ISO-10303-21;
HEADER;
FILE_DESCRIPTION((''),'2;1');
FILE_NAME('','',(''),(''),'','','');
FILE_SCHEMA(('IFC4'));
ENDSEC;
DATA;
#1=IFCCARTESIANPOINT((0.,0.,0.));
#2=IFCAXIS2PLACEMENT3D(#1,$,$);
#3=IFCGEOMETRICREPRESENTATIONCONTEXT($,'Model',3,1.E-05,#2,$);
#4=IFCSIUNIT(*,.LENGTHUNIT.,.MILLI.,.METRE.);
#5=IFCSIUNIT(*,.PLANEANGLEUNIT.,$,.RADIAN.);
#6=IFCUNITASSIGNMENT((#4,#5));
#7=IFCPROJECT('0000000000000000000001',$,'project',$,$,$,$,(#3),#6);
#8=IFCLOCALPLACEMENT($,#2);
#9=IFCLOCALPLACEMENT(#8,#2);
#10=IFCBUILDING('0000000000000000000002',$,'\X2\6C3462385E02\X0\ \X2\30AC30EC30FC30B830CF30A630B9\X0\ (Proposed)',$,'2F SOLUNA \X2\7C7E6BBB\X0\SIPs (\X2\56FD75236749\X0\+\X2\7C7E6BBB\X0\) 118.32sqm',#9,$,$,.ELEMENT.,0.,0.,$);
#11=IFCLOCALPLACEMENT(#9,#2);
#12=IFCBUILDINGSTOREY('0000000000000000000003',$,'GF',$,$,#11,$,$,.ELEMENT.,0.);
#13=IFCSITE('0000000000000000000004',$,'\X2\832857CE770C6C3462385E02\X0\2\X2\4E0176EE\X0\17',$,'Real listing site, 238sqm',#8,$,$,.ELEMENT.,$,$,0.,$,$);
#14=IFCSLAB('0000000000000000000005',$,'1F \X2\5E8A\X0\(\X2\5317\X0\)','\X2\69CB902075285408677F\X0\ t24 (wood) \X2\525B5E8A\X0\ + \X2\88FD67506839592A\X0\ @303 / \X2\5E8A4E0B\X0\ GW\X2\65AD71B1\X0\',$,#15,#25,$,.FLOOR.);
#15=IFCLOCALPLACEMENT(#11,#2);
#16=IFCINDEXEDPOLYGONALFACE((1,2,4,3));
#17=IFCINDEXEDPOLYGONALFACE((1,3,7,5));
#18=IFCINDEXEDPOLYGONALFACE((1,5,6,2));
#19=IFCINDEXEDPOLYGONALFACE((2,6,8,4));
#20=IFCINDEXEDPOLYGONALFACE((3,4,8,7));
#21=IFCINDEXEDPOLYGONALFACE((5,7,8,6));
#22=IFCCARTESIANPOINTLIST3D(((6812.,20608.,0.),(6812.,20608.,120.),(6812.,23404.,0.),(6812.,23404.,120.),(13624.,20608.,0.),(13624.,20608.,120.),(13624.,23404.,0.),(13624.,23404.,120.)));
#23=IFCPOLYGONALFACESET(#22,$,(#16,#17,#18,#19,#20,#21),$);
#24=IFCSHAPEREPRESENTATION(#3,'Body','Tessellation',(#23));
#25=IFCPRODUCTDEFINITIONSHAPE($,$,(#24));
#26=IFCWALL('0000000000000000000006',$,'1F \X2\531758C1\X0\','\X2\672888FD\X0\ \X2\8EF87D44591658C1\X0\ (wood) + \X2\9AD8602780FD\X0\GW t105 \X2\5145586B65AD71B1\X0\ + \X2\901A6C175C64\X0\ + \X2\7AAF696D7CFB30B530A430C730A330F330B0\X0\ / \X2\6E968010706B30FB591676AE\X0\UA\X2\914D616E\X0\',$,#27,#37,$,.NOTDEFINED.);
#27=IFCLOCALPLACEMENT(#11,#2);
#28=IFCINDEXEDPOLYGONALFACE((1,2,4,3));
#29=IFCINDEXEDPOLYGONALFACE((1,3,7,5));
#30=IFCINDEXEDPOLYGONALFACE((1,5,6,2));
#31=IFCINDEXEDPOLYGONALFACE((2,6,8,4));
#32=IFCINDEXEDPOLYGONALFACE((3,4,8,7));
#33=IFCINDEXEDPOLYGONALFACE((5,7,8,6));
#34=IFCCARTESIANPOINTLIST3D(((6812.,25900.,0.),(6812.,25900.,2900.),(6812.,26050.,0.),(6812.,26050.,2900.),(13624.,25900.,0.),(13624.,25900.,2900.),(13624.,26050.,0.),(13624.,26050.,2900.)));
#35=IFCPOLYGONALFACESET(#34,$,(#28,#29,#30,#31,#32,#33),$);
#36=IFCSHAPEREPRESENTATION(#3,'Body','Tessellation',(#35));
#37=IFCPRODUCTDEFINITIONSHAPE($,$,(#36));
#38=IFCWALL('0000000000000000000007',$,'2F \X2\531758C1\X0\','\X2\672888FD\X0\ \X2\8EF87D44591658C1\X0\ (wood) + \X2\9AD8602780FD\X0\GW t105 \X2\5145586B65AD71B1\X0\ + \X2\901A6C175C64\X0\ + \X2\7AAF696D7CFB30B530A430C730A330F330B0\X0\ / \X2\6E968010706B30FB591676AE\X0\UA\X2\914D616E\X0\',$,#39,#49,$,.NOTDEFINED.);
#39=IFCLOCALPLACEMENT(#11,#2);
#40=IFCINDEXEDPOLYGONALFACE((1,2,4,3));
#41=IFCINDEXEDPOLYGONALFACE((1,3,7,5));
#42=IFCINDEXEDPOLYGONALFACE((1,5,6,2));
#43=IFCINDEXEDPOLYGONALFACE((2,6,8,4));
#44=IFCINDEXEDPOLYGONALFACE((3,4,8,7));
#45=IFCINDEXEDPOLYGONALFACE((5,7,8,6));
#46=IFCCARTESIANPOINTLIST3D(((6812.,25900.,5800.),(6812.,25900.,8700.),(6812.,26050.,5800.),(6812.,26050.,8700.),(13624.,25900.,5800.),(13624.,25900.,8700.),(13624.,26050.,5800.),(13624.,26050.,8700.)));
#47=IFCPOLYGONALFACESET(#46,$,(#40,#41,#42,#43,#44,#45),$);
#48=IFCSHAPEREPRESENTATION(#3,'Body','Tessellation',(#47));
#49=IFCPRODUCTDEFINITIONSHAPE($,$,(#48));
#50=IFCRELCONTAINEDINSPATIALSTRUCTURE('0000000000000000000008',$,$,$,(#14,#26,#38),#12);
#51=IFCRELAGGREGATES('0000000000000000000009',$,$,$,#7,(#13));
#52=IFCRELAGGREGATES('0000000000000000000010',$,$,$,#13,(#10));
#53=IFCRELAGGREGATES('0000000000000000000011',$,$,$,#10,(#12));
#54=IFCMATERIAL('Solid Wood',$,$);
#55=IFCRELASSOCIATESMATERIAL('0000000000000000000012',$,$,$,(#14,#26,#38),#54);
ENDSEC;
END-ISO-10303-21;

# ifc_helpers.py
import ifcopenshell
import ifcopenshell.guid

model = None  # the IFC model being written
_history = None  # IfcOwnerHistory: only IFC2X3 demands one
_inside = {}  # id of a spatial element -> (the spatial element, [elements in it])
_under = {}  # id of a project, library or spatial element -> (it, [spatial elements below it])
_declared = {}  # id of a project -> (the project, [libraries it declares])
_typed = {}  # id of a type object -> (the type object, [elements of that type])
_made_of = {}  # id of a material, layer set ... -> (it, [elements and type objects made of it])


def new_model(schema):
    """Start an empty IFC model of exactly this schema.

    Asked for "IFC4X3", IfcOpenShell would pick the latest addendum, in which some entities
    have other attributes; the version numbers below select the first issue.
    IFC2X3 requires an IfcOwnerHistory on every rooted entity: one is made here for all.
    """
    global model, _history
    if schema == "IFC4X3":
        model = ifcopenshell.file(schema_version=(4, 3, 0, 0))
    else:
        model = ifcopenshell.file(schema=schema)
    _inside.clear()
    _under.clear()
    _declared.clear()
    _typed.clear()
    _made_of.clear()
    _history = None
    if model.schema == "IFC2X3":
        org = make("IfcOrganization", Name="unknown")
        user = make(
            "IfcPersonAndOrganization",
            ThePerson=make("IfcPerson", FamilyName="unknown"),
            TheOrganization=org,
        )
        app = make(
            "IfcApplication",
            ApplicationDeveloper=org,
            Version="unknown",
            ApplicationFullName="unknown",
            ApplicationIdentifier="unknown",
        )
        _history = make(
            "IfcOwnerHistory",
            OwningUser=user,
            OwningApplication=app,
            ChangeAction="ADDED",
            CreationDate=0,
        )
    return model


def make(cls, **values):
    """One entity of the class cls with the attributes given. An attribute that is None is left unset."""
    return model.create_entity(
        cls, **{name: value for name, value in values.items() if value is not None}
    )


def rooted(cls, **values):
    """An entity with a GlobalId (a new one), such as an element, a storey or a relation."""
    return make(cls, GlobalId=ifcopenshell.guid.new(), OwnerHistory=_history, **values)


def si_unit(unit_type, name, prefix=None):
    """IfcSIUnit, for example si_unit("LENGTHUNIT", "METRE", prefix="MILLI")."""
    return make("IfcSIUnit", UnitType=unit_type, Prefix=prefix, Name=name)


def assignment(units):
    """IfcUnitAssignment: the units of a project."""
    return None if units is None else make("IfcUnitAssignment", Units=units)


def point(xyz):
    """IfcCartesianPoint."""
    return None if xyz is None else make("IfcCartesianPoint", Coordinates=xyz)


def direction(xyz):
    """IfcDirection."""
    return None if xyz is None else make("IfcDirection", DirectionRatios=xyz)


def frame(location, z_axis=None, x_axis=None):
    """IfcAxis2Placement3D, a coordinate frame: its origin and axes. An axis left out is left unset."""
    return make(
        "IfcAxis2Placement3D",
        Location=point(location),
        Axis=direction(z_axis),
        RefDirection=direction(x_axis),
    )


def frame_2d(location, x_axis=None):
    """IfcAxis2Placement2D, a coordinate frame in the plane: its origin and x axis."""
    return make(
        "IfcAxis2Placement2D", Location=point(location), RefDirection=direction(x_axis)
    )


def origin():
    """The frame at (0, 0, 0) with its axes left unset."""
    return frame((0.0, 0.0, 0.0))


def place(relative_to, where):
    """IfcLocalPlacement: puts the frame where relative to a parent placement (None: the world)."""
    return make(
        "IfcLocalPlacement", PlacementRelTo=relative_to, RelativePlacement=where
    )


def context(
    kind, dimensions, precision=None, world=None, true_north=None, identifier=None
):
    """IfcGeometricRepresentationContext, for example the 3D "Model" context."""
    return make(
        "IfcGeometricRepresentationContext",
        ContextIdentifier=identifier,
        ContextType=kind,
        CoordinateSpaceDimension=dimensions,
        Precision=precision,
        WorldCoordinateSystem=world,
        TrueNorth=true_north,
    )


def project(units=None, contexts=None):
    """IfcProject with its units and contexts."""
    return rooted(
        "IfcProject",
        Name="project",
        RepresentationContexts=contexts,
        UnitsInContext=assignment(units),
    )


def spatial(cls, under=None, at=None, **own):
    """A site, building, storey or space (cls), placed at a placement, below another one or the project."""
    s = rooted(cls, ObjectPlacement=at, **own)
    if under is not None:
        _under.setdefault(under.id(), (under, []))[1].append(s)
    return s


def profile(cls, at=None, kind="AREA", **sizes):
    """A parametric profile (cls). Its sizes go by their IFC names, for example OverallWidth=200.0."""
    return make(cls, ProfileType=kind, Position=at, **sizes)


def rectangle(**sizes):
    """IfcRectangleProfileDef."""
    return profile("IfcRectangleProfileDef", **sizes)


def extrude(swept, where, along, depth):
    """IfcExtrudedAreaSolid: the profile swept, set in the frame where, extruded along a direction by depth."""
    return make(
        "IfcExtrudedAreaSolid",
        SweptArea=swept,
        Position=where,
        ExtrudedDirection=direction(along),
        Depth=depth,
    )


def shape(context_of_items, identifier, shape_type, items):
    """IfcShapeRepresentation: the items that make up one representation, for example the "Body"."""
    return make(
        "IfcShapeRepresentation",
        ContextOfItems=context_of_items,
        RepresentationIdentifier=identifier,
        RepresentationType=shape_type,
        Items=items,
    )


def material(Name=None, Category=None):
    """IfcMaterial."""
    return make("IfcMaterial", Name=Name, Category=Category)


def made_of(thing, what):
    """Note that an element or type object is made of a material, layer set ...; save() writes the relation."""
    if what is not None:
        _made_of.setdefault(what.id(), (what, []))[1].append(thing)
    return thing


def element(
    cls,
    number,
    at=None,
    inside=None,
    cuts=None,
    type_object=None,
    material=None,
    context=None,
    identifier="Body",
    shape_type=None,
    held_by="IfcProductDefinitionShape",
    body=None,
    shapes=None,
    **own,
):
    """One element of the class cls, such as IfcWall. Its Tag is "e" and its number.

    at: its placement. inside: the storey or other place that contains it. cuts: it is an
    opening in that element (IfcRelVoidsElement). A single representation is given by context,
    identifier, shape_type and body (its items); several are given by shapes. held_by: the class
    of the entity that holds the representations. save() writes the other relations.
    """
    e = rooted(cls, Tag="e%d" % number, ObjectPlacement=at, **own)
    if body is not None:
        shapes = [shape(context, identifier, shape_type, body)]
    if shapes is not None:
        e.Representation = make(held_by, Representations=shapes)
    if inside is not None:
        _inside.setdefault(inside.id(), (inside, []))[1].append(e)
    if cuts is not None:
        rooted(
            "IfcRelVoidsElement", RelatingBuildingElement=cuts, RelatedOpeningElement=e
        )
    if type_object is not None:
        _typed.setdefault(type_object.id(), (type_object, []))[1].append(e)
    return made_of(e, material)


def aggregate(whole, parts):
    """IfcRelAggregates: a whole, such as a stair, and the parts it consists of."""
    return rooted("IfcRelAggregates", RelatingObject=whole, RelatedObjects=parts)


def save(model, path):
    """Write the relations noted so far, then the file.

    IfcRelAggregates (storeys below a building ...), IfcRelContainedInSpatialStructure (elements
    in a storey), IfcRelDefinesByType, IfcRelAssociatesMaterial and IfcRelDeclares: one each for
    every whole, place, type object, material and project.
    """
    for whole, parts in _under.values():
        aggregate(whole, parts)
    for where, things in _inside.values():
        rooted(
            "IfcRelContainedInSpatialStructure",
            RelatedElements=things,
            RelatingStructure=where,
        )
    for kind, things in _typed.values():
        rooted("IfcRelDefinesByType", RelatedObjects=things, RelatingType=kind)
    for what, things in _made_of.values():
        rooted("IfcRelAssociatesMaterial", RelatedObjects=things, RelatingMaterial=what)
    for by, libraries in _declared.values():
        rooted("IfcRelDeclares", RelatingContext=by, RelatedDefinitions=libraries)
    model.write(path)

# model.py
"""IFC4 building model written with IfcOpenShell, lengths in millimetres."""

from ifc_helpers import new_model, si_unit, frame, frame_2d, origin, place, context, project, spatial, rectangle, extrude, material, element, save


model = new_model("IFC4")

# Units and contexts
model_context = context("Model", 3, precision=1e-05, world=origin())
ifc_project = project(units=[si_unit("LENGTHUNIT", "METRE", prefix="MILLI"), si_unit("PLANEANGLEUNIT", "RADIAN")], contexts=[model_context])

# Site, building, storey
site_placement = place(None, origin())
site = spatial("IfcSite", under=ifc_project, at=site_placement, Name="茨城県水戸市2丁目17", ObjectType="Real listing site, 238sqm", CompositionType="ELEMENT", RefElevation=0.0)
building_placement = place(site_placement, origin())
building = spatial("IfcBuilding", under=site, at=building_placement, Name="水戸市 ガレージハウス (Proposed)", ObjectType="2F SOLUNA 籾殻SIPs (国産杉+籾殻) 118.32sqm", CompositionType="ELEMENT", ElevationOfRefHeight=0.0, ElevationOfTerrain=0.0)
storey_placement = place(building_placement, origin())
storey = spatial("IfcBuildingStorey", under=building, at=storey_placement, Name="GF", CompositionType="ELEMENT", Elevation=0.0)

# Slab
ifc_material_1 = material(Name="Solid Wood")
slab_1_placement = place(storey_placement, frame((3406.0, 10304.0, 0.0)))
element("IfcSlab", 1, at=slab_1_placement, inside=storey, material=ifc_material_1, Name="1F 床(北)", Description="構造用合板 t24 (wood) 剛床 + 製材根太 @303 / 床下 GW断熱", PredefinedType="FLOOR", context=model_context, shape_type="SweptSolid", body=[
    extrude(rectangle(XDim=6812.0, YDim=2796.0, at=frame_2d((3406.0, 1398.0))), frame((3406.0, 10304.0, 0.0)), (0.0, 0.0, 1.0), 120.0),
])

# Wall
wall_1_placement = place(storey_placement, frame((3406.0, 12950.0, 0.0)))
element("IfcWall", 2, at=wall_1_placement, inside=storey, material=ifc_material_1, Name="1F 北壁", Description="木製 軸組外壁 (wood) + 高性能GW t105 充填断熱 + 通気層 + 窯業系サイディング / 準耐火・外皮UA配慮", PredefinedType="NOTDEFINED", context=model_context, shape_type="SweptSolid", body=[
    extrude(rectangle(XDim=6812.0, YDim=150.0, at=frame_2d((3406.0, 75.0))), frame((3406.0, 12950.0, 0.0)), (0.0, 0.0, 1.0), 2900.0),
])

# Wall
wall_2_placement = place(storey_placement, frame((3406.0, 12950.0, 2900.0)))
element("IfcWall", 3, at=wall_2_placement, inside=storey, material=ifc_material_1, Name="2F 北壁", Description="木製 軸組外壁 (wood) + 高性能GW t105 充填断熱 + 通気層 + 窯業系サイディング / 準耐火・外皮UA配慮", PredefinedType="NOTDEFINED", context=model_context, shape_type="SweptSolid", body=[
    extrude(rectangle(XDim=6812.0, YDim=150.0, at=frame_2d((3406.0, 75.0))), frame((3406.0, 12950.0, 2900.0)), (0.0, 0.0, 1.0), 2900.0),
])

save(model, "model.ifc")
